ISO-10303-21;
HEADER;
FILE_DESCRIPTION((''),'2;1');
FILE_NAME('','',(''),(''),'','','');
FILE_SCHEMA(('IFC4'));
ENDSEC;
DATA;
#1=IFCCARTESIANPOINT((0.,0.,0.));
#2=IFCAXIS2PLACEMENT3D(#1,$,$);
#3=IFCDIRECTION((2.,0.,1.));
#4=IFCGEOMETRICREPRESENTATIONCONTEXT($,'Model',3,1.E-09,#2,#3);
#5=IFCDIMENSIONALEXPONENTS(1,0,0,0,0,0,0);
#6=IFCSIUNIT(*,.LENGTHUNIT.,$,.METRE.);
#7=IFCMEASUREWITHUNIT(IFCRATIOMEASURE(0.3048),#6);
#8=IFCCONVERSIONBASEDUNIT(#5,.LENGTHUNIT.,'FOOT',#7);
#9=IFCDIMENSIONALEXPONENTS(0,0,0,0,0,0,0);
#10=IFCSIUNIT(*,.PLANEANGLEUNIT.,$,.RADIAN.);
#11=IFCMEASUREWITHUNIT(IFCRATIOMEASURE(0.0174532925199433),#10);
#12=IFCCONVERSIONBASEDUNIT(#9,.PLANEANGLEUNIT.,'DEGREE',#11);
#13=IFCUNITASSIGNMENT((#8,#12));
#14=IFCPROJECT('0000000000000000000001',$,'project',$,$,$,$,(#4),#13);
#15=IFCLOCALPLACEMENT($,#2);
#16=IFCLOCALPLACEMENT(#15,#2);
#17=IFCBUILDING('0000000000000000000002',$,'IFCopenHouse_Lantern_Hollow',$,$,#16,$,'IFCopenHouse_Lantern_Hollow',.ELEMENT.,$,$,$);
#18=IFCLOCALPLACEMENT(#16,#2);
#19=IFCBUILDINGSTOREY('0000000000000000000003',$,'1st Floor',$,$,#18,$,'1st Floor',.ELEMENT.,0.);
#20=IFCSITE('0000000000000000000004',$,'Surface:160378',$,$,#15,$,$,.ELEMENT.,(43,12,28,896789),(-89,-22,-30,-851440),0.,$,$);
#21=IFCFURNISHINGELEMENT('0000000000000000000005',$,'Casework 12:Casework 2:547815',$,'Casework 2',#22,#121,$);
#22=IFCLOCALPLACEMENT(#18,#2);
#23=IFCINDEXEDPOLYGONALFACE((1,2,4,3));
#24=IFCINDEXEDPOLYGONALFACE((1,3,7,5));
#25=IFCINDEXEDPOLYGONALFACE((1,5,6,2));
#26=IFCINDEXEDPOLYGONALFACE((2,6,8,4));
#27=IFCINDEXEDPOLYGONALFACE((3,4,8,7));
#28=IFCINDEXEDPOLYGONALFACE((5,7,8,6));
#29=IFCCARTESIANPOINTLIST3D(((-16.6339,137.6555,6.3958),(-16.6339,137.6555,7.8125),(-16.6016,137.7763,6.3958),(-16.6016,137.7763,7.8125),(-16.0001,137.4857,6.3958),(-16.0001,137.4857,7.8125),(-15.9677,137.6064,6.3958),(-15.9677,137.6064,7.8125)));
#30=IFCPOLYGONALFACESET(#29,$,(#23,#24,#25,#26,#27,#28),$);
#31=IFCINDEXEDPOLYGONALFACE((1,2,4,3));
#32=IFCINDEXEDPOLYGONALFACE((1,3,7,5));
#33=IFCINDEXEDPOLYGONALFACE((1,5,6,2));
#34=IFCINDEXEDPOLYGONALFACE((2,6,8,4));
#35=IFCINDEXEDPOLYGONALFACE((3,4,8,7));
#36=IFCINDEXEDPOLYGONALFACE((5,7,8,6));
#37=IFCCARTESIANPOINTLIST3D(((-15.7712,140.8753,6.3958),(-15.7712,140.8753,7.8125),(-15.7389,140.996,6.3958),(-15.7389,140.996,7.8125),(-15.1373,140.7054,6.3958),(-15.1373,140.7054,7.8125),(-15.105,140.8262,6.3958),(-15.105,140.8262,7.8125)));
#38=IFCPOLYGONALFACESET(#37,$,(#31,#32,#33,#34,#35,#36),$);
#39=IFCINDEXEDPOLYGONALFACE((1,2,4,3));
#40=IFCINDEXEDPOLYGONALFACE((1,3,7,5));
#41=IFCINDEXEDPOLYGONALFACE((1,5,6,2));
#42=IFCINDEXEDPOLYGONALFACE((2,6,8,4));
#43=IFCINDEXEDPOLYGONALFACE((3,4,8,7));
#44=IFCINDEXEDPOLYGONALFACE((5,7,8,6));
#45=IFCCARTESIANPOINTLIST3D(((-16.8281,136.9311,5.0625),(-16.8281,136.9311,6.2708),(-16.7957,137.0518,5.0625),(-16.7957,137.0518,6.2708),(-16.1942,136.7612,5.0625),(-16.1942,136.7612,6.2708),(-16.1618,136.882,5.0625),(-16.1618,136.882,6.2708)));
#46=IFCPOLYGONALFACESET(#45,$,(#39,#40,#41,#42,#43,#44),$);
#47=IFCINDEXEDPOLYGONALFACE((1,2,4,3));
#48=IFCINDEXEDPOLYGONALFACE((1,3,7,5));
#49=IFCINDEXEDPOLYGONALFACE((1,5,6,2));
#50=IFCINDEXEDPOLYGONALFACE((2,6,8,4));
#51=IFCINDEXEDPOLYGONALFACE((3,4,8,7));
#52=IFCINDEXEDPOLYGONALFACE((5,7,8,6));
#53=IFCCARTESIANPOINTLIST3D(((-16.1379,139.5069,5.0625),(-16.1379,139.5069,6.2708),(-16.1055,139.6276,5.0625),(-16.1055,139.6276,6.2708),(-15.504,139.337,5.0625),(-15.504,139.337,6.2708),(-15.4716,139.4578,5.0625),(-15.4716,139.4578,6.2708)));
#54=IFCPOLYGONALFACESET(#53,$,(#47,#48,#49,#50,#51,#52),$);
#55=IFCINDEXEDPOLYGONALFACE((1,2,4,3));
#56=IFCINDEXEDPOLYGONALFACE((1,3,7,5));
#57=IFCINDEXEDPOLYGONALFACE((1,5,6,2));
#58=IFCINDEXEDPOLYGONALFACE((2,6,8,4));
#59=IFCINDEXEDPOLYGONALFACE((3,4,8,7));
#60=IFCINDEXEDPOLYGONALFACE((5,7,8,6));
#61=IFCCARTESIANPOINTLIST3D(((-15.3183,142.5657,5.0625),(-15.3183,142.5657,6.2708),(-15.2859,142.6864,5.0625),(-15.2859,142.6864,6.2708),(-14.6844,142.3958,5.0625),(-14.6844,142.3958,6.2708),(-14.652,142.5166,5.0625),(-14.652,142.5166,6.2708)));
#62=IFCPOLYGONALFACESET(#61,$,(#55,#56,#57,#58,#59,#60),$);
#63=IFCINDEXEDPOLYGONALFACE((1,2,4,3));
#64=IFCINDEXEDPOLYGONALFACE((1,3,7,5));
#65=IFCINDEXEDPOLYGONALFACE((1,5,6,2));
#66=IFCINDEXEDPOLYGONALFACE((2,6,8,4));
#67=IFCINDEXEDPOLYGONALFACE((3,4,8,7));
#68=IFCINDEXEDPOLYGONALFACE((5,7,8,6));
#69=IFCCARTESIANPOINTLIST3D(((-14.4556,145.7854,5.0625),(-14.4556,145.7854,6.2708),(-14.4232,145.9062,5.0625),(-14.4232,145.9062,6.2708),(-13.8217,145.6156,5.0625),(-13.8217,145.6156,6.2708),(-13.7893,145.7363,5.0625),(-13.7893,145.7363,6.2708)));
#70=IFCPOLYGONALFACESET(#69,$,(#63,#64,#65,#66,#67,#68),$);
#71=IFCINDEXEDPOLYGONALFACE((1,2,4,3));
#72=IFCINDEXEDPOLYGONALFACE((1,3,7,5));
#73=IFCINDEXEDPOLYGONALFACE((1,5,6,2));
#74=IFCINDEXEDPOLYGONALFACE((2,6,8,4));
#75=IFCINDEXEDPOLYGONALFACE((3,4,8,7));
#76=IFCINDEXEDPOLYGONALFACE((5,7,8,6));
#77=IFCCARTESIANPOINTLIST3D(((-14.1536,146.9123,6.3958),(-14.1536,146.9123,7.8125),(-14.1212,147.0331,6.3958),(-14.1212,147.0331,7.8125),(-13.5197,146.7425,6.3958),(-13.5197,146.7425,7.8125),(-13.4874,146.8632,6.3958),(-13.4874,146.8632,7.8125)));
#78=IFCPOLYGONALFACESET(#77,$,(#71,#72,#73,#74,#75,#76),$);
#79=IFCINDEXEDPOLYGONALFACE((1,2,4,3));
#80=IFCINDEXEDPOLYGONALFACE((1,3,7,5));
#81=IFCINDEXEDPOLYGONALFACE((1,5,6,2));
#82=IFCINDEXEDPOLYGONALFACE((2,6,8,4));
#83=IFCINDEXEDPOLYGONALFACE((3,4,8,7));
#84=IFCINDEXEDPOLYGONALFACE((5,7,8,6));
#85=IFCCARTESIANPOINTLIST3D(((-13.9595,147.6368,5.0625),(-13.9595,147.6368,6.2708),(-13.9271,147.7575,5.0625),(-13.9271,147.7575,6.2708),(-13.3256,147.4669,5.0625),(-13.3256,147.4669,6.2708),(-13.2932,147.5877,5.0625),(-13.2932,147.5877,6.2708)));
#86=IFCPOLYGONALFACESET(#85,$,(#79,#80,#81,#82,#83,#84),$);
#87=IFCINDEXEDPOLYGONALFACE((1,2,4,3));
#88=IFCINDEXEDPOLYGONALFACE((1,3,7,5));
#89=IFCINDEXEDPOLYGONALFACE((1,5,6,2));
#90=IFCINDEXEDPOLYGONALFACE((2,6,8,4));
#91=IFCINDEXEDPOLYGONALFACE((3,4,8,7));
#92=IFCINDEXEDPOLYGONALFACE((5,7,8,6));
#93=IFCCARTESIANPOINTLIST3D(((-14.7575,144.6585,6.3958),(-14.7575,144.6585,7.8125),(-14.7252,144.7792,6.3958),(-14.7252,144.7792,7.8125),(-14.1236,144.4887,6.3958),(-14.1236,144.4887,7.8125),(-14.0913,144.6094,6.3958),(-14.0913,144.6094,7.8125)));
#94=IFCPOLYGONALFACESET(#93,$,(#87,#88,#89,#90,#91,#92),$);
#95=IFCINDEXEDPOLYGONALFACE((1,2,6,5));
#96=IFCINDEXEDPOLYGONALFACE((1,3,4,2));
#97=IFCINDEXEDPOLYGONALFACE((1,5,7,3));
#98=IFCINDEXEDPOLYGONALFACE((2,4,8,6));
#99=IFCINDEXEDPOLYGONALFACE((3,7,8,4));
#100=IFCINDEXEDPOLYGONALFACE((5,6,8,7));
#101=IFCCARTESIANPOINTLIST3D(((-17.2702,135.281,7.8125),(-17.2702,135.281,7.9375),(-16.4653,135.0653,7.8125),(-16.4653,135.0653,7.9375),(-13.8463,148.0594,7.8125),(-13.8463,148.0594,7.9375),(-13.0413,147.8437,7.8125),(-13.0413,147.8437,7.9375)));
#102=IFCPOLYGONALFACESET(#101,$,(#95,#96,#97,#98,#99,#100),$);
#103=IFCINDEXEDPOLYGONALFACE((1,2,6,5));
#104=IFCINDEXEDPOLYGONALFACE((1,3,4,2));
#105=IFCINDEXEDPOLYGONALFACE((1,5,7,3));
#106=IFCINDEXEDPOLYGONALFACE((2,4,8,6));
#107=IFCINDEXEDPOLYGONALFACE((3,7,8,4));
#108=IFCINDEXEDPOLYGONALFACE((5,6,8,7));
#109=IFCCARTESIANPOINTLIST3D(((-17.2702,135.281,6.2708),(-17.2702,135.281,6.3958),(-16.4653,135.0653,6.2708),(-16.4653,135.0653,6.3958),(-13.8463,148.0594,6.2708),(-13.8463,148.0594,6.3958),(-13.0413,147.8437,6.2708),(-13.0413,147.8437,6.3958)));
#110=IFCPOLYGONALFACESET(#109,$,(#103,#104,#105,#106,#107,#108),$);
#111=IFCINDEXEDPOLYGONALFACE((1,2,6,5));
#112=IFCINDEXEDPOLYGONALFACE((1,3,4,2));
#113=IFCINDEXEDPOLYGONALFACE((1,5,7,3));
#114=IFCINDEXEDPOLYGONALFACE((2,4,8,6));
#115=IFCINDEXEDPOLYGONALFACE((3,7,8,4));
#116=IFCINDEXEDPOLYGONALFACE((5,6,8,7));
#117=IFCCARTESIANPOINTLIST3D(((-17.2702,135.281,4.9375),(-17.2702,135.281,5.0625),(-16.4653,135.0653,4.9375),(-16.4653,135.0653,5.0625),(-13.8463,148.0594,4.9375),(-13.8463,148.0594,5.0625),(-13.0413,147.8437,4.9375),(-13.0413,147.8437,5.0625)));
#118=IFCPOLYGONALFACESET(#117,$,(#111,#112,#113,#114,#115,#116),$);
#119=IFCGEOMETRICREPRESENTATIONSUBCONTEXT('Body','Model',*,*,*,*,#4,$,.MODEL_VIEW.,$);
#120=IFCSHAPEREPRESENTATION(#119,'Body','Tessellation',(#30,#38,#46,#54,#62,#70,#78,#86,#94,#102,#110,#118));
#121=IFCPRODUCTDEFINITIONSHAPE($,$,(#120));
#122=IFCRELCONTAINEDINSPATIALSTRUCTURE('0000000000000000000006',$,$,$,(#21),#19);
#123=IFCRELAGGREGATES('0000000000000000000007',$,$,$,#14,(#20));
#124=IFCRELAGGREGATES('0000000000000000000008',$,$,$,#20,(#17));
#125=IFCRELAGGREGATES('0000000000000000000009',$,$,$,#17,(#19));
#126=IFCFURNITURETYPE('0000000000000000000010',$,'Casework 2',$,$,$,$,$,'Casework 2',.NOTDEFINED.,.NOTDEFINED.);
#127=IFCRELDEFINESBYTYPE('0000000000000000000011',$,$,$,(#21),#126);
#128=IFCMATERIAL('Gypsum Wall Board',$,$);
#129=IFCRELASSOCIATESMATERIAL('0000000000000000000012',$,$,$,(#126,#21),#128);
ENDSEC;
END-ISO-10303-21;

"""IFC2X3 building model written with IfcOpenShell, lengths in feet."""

from ifc_helpers import new_model, entity, si_unit, converted_unit, direction, frame, frame_2d, origin, place, context, subcontext, project, spatial, rectangle, extrude, source, transform, mapped, material, type_object, type_shapes, element, save


model = new_model("IFC2X3")

# Units and contexts
model_context = context("Model", 3, precision=1e-09, world=origin(), true_north=direction((2.0, 0.0, 1.0)))
body_context = subcontext(model_context, "Body", "Model", "MODEL_VIEW")
ifc_project = project(units=[converted_unit("LENGTHUNIT", "FOOT", entity("IfcRatioMeasure", 0.3048), si_unit("LENGTHUNIT", "METRE"), dimensions=[1, 0, 0, 0, 0, 0, 0]), converted_unit("PLANEANGLEUNIT", "DEGREE", entity("IfcRatioMeasure", 0.0174532925199433), si_unit("PLANEANGLEUNIT", "RADIAN"), dimensions=[0, 0, 0, 0, 0, 0, 0])], contexts=[model_context])

# Site, building, storey
site_placement = place(None, origin())
site = spatial("IfcSite", under=ifc_project, at=site_placement, Name="Surface:160378", CompositionType="ELEMENT", RefLatitude=(43, 12, 28, 896789), RefLongitude=(-89, -22, -30, -851440), RefElevation=0.0)
building_placement = place(site_placement, origin())
building = spatial("IfcBuilding", under=site, at=building_placement, Name="IFCopenHouse_Lantern_Hollow", LongName="IFCopenHouse_Lantern_Hollow", CompositionType="ELEMENT")
storey_placement = place(building_placement, origin())
storey = spatial("IfcBuildingStorey", under=building, at=storey_placement, Name="1st Floor", LongName="1st Floor", CompositionType="ELEMENT", Elevation=0.0)

# Shared definitions
ifc_material_1 = material(Name="Gypsum Wall Board")

# Furnishing element
furniture_type_1 = type_object("IfcFurnitureType", Name="Casework 2", ElementType="Casework 2", AssemblyPlace="NOTDEFINED", material=ifc_material_1)
shared_shape_1 = source(origin(), body_context, "Body", "SweptSolid", [
    extrude(rectangle(XDim=0.6563, YDim=0.125, at=frame_2d((0.0, 0.0), x_axis=(1.0, 0.0))), frame((0.9694, 2.5657, 1.4583), z_axis=(0.0, 0.0, 1.0), x_axis=(-0.965926, 0.258819, 0.0)), (0.0, 0.0, 1.0), 1.4167),
    extrude(rectangle(XDim=0.6563, YDim=0.125, at=frame_2d((0.0, 0.0), x_axis=(1.0, 0.0))), frame((1.8321, 5.7854, 1.4583), z_axis=(0.0, 0.0, 1.0), x_axis=(-0.965926, 0.258819, 0.0)), (0.0, 0.0, 1.0), 1.4167),
    extrude(rectangle(XDim=0.6563, YDim=0.125, at=frame_2d((0.0, 0.0), x_axis=(1.0, 0.0))), frame((0.7753, 1.8413, 0.125), z_axis=(0.0, 0.0, 1.0), x_axis=(-0.965926, 0.258819, 0.0)), (0.0, 0.0, 1.0), 1.2083),
    extrude(rectangle(XDim=0.6563, YDim=0.125, at=frame_2d((0.0, 0.0), x_axis=(1.0, 0.0))), frame((1.4655, 4.4171, 0.125), z_axis=(0.0, 0.0, 1.0), x_axis=(-0.965926, 0.258819, 0.0)), (0.0, 0.0, 1.0), 1.2083),
    extrude(rectangle(XDim=0.6563, YDim=0.125, at=frame_2d((0.0, 0.0), x_axis=(1.0, 0.0))), frame((2.285, 7.4758, 0.125), z_axis=(0.0, 0.0, 1.0), x_axis=(-0.965926, 0.258819, 0.0)), (0.0, 0.0, 1.0), 1.2083),
    extrude(rectangle(XDim=0.6563, YDim=0.125, at=frame_2d((0.0, 0.0), x_axis=(1.0, 0.0))), frame((3.1478, 10.6956, 0.125), z_axis=(0.0, 0.0, 1.0), x_axis=(-0.965926, 0.258819, 0.0)), (0.0, 0.0, 1.0), 1.2083),
    extrude(rectangle(XDim=0.6563, YDim=0.125, at=frame_2d((0.0, 0.0), x_axis=(1.0, 0.0))), frame((3.4497, 11.8225, 1.4583), z_axis=(0.0, 0.0, 1.0), x_axis=(-0.965926, 0.258819, 0.0)), (0.0, 0.0, 1.0), 1.4167),
    extrude(rectangle(XDim=0.6563, YDim=0.125, at=frame_2d((0.0, 0.0), x_axis=(1.0, 0.0))), frame((3.6438, 12.5469, 0.125), z_axis=(0.0, 0.0, 1.0), x_axis=(-0.965926, 0.258819, 0.0)), (0.0, 0.0, 1.0), 1.2083),
    extrude(rectangle(XDim=0.6563, YDim=0.125, at=frame_2d((0.0, 0.0), x_axis=(1.0, 0.0))), frame((2.8458, 9.5687, 1.4583), z_axis=(0.0, 0.0, 1.0), x_axis=(-0.965926, 0.258819, 0.0)), (0.0, 0.0, 1.0), 1.4167),
    extrude(rectangle(XDim=13.2292, YDim=0.8333, at=frame_2d((0.0, 0.0), x_axis=(1.0, 0.0))), frame((2.1144, 6.497, 2.875), z_axis=(0.0, 0.0, 1.0), x_axis=(0.258819, 0.965926, 0.0)), (0.0, 0.0, 1.0), 0.125),
    extrude(rectangle(XDim=13.2292, YDim=0.8333, at=frame_2d((0.0, 0.0), x_axis=(1.0, 0.0))), frame((2.1144, 6.497, 1.3333), z_axis=(0.0, 0.0, 1.0), x_axis=(0.258819, 0.965926, 0.0)), (0.0, 0.0, 1.0), 0.125),
    extrude(rectangle(XDim=13.2292, YDim=0.8333, at=frame_2d((0.0, 0.0), x_axis=(1.0, 0.0))), frame((2.1144, 6.497, 0.0), z_axis=(0.0, 0.0, 1.0), x_axis=(0.258819, 0.965926, 0.0)), (0.0, 0.0, 1.0), 0.125),
])
type_shapes(furniture_type_1, [shared_shape_1])
furnishing_1_placement = place(storey_placement, frame((-17.2702, 135.0653, 4.9375)))
element("IfcFurnishingElement", 1, at=furnishing_1_placement, inside=storey, type_object=furniture_type_1, material=ifc_material_1, Name="Casework 12:Casework 2:547815", ObjectType="Casework 2", context=body_context, shape_type="MappedRepresentation", body=[
    mapped(shared_shape_1, transform((0.0, 0.0, 0.0), scale=1.0)),
])

save(model, "model.ifc")
